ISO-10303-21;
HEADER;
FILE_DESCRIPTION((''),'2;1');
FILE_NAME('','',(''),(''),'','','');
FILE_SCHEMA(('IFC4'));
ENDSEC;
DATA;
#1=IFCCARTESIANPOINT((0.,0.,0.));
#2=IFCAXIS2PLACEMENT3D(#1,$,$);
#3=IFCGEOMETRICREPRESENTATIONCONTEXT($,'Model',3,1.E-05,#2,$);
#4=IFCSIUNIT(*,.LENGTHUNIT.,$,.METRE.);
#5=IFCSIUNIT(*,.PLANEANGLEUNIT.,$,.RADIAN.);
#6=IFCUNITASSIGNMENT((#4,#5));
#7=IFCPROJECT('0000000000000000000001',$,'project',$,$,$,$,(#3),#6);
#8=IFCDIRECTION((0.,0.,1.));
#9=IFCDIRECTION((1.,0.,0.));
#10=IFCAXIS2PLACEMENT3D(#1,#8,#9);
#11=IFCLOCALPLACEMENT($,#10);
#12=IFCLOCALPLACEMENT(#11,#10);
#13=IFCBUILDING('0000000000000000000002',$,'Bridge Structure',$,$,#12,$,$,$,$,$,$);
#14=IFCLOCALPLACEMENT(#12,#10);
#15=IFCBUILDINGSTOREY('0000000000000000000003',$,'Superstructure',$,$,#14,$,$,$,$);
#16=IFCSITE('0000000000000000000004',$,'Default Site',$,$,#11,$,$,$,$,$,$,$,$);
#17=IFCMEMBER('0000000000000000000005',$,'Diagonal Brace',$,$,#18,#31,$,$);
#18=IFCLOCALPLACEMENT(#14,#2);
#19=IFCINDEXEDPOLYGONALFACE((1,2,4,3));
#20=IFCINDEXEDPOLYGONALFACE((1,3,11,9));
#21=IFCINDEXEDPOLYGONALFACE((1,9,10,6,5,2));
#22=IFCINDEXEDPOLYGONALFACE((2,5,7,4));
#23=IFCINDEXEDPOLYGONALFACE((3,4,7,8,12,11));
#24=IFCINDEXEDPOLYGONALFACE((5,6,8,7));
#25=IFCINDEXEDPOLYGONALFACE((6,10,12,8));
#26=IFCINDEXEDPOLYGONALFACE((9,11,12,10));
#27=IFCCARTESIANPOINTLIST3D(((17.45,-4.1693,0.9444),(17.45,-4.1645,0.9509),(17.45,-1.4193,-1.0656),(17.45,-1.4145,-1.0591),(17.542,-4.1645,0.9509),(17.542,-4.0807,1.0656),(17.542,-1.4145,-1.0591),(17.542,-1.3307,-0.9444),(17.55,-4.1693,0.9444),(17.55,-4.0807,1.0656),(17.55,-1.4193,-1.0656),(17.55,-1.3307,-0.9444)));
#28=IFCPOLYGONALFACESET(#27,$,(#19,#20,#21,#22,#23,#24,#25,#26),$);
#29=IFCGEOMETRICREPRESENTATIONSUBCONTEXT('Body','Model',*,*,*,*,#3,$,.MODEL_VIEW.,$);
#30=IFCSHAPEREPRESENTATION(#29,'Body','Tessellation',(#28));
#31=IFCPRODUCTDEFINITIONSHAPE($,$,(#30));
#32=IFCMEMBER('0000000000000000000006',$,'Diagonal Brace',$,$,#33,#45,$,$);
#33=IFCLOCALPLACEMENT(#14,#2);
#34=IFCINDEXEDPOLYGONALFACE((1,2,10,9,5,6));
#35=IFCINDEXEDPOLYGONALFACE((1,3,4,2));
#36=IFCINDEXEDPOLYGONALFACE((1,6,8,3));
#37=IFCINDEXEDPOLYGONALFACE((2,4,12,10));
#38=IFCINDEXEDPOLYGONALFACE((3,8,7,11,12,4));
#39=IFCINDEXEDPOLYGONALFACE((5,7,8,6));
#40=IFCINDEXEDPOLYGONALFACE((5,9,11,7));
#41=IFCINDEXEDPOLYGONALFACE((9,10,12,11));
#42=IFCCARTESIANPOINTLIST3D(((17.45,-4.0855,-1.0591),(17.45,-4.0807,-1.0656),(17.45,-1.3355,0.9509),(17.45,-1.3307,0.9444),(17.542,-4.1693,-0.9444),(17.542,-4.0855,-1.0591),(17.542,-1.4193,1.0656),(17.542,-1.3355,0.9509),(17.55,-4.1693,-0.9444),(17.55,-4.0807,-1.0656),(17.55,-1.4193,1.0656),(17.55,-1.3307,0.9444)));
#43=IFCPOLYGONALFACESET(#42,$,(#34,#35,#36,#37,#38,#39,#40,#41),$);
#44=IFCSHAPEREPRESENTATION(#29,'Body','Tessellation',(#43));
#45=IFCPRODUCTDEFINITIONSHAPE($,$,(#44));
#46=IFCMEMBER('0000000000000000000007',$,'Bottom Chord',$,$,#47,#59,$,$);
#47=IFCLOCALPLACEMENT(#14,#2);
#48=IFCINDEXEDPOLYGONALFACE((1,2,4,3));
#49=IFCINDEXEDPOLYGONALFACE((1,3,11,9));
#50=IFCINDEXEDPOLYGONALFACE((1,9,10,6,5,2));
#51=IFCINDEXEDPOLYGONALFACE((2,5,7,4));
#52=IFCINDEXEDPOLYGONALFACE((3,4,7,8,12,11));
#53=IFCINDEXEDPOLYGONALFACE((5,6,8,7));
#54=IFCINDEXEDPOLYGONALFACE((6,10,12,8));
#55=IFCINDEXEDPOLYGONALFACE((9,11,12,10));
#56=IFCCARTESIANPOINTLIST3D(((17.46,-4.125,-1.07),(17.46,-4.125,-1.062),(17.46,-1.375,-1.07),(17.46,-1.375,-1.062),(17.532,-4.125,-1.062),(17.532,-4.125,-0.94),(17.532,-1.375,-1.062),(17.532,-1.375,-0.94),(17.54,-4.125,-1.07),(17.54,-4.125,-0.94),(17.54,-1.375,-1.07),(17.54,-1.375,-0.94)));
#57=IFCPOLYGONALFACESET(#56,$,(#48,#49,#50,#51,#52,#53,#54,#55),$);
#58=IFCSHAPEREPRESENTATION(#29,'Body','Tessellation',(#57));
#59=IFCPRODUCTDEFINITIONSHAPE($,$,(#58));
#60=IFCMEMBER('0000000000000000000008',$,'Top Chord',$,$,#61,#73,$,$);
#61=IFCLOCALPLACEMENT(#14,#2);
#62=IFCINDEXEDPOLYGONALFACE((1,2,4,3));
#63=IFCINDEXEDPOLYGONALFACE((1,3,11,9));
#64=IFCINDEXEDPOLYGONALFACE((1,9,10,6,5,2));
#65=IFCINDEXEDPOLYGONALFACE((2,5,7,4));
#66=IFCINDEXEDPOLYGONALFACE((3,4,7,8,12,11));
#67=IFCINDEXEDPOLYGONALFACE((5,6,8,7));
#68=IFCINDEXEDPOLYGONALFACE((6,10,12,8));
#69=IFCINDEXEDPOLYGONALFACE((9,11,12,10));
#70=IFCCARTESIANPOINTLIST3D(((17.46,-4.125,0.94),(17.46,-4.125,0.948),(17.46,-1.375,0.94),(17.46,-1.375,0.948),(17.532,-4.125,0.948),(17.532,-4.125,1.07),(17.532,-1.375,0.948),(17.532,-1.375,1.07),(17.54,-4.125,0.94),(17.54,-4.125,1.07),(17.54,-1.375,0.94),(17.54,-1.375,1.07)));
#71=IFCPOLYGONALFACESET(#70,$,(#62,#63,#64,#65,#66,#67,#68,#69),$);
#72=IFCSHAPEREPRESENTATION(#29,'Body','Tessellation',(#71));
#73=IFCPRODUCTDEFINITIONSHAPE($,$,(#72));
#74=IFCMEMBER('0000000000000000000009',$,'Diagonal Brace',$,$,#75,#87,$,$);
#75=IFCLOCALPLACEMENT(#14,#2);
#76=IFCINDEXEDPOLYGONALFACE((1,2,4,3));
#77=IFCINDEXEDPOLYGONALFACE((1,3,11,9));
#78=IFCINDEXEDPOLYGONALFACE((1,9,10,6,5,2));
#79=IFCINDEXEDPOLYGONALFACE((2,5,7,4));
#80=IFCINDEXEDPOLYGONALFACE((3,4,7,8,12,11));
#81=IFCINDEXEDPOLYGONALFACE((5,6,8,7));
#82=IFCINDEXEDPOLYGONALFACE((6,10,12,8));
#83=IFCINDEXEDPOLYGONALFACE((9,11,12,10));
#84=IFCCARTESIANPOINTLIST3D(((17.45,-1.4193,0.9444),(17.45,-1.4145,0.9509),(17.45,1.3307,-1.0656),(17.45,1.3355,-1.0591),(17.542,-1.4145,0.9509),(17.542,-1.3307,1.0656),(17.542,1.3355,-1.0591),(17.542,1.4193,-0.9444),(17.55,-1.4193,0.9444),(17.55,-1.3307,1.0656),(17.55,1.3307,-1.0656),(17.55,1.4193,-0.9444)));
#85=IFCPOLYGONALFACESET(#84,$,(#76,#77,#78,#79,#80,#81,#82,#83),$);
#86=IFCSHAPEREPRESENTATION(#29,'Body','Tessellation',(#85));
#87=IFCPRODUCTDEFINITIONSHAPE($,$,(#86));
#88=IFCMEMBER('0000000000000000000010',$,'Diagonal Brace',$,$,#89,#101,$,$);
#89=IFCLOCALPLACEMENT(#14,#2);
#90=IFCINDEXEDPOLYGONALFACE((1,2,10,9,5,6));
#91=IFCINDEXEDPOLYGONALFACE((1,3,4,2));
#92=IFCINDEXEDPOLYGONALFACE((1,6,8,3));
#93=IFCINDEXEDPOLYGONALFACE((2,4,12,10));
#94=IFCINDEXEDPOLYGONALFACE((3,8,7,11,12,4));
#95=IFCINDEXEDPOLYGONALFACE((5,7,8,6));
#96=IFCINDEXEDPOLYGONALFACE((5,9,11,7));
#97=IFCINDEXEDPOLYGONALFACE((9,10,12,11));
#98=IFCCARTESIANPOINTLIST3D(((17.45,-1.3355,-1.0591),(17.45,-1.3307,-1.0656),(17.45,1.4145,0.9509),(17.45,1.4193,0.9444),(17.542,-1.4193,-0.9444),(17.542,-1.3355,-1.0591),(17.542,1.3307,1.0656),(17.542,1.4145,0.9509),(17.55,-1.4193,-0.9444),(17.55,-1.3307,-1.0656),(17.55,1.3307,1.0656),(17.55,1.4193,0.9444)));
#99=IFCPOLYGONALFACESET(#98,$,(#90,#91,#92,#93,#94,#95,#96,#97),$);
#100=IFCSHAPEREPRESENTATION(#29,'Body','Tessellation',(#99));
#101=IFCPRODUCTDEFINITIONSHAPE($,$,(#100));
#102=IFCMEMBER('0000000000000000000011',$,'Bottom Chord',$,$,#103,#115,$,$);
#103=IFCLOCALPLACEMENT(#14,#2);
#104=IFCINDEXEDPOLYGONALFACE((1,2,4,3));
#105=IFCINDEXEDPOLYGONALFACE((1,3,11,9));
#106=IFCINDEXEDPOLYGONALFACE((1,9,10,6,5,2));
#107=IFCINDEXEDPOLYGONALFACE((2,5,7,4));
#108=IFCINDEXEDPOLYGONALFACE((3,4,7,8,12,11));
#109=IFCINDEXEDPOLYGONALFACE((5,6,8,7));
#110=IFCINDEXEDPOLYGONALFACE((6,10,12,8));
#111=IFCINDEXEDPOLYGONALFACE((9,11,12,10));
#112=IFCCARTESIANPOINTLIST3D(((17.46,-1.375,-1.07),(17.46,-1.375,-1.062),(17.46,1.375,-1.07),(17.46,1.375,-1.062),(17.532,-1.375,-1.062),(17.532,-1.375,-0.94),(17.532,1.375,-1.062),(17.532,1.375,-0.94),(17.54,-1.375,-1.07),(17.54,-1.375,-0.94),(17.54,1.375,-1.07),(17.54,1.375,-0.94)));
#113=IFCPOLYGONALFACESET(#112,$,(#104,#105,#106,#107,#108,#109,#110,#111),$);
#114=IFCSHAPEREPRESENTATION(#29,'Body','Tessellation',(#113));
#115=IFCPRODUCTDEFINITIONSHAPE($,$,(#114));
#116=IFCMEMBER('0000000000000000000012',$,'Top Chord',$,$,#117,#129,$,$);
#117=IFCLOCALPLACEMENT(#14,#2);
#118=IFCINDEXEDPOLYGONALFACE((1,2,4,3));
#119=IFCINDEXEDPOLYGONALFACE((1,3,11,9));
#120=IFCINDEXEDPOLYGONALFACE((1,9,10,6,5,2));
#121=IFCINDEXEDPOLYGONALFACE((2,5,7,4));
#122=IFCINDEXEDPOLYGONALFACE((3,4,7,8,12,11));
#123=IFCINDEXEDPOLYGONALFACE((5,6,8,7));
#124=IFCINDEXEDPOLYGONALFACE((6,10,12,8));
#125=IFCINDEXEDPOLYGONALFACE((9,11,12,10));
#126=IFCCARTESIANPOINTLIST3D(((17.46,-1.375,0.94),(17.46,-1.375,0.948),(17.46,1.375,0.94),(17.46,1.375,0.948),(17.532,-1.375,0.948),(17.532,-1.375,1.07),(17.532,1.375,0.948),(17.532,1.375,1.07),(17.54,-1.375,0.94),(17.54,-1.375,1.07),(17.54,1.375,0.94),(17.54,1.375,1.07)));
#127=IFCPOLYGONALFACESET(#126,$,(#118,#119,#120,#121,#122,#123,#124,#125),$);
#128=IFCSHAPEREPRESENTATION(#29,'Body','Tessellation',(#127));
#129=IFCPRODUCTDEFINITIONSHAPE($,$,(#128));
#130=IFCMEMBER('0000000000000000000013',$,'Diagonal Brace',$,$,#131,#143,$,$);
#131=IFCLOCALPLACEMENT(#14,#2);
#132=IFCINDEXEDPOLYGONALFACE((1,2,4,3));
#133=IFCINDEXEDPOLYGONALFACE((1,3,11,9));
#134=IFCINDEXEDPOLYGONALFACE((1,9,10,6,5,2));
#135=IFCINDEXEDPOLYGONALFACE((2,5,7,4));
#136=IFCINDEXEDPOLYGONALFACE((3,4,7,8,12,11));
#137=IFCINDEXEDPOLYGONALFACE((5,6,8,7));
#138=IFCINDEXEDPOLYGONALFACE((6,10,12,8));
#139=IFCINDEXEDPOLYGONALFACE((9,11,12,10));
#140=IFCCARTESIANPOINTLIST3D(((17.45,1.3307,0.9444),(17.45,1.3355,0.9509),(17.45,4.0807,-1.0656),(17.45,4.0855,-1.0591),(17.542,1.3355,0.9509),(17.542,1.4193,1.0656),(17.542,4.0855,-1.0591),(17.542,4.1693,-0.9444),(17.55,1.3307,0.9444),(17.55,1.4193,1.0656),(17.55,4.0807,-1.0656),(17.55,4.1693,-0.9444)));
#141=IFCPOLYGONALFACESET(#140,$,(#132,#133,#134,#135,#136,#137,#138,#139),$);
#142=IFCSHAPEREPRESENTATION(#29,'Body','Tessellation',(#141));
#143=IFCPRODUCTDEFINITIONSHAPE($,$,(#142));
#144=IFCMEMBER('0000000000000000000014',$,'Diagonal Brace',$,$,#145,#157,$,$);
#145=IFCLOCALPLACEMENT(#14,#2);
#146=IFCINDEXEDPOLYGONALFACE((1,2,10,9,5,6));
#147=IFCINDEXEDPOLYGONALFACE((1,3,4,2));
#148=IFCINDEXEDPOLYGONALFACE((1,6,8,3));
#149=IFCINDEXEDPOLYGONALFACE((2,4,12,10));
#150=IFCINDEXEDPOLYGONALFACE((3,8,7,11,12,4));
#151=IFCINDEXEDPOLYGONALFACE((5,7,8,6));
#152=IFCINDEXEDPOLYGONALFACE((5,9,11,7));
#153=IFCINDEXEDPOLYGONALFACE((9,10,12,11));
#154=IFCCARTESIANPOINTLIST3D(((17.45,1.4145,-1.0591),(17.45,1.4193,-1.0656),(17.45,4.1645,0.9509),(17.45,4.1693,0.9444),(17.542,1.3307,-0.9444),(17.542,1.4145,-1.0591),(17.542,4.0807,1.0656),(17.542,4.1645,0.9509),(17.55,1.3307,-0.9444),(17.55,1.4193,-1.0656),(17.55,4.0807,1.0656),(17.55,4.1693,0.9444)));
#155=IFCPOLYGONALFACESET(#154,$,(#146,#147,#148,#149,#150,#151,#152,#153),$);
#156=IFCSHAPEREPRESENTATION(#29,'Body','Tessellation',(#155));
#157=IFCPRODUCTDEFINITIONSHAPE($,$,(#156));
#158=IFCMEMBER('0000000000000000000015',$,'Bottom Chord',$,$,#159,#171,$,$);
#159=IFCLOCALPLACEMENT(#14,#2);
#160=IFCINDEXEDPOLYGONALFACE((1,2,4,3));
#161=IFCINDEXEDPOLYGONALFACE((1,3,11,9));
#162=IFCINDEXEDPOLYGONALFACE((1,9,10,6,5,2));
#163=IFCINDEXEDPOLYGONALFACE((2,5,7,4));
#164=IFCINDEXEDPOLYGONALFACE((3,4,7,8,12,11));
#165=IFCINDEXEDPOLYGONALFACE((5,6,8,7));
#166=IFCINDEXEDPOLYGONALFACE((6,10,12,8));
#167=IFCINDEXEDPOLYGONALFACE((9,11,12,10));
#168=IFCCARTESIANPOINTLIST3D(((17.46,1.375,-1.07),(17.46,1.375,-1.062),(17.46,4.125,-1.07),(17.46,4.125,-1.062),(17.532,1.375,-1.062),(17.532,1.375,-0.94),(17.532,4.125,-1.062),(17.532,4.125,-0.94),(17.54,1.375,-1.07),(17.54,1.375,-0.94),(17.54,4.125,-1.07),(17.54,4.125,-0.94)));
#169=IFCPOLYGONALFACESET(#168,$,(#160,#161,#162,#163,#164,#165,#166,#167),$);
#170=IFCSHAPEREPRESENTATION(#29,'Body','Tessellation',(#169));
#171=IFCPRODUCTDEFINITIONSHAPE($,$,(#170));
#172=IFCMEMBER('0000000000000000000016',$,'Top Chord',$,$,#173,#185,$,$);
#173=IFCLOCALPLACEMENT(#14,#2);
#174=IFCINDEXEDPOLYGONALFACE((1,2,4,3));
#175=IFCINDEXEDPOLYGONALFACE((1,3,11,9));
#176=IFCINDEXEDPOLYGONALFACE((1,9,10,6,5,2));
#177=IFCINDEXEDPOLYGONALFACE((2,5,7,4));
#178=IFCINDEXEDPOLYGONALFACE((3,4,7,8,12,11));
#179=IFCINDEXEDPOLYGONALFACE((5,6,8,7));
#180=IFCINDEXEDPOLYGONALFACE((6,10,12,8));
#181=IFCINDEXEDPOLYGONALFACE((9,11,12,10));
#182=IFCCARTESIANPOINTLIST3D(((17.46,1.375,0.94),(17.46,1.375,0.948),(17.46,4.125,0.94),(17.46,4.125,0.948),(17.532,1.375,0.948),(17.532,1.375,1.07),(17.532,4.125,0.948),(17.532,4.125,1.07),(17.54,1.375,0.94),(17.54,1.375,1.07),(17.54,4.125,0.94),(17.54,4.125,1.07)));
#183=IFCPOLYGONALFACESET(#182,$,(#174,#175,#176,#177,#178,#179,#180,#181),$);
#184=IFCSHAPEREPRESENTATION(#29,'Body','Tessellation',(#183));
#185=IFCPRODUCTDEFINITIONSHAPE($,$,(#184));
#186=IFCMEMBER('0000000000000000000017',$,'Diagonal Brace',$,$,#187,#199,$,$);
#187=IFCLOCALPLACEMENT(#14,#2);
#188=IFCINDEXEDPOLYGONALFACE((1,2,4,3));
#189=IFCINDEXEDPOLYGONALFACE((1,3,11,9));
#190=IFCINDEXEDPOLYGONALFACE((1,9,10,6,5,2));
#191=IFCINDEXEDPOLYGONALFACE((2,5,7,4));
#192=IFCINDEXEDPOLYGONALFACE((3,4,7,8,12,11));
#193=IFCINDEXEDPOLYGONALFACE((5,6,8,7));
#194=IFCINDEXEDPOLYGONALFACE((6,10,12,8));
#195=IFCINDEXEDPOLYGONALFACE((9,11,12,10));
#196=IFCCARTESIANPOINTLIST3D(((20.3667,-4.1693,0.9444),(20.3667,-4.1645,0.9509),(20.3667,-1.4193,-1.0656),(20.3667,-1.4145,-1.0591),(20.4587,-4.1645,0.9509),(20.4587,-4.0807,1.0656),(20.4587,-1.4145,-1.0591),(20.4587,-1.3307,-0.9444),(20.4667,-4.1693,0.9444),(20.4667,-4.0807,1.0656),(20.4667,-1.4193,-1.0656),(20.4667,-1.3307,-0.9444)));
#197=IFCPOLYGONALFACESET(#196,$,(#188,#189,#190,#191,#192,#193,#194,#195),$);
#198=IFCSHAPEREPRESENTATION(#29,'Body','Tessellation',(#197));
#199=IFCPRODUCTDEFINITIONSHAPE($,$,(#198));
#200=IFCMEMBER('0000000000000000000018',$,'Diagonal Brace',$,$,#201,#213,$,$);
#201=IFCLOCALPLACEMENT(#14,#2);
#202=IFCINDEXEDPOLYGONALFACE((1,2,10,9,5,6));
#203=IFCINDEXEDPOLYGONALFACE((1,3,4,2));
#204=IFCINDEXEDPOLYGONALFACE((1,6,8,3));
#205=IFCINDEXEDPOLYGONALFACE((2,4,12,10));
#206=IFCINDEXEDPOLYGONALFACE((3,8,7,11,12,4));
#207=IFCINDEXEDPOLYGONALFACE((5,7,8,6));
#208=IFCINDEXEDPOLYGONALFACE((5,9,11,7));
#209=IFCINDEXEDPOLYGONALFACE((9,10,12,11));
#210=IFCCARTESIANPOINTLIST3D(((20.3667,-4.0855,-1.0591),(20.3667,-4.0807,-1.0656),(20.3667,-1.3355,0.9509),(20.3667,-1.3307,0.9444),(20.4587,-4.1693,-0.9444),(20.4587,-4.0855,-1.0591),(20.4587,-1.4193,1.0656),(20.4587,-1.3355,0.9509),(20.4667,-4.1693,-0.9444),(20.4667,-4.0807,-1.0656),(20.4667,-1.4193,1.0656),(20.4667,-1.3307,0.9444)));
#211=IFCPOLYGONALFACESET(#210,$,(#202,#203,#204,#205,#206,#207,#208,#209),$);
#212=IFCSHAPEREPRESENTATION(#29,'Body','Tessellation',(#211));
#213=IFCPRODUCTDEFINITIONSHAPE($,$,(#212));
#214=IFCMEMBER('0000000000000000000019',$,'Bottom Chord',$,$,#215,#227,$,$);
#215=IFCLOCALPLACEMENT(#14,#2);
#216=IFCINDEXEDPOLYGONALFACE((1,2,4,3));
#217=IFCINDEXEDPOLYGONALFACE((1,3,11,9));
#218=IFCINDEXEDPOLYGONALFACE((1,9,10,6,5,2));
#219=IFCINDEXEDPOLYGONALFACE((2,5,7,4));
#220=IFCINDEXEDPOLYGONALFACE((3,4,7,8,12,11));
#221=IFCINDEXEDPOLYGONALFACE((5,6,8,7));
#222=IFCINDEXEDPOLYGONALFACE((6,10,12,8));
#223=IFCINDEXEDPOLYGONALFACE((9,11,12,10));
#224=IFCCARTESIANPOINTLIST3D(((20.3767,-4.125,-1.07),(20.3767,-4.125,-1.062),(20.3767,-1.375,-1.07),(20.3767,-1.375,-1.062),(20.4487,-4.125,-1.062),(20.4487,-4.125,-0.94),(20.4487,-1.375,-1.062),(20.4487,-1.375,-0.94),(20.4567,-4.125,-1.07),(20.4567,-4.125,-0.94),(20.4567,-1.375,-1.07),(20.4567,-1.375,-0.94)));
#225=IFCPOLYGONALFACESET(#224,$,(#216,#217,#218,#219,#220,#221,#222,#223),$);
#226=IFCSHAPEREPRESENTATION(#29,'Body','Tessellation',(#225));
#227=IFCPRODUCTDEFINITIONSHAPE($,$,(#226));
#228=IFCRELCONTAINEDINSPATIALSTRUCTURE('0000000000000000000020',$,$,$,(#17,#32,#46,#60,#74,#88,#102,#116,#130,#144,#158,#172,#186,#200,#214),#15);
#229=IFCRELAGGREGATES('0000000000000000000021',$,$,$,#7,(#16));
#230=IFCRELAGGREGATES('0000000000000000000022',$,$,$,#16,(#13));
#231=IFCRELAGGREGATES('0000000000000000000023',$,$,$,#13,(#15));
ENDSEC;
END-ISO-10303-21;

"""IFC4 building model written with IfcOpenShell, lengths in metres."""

from ifc_helpers import new_model, si_unit, frame, origin, origin_with_axes, origin_2d_with_axis, place, context, subcontext, project, spatial, l_section, extrude, element, save


model = new_model("IFC4")

# Units and contexts
model_context = context("Model", 3, precision=1e-05, world=origin())
body_context = subcontext(model_context, "Body", "Model", "MODEL_VIEW")
ifc_project = project(units=[si_unit("LENGTHUNIT", "METRE"), si_unit("PLANEANGLEUNIT", "RADIAN")], contexts=[model_context])

# Site, building, storey
site_placement = place(None, origin_with_axes())
site = spatial("IfcSite", under=ifc_project, at=site_placement, Name="Default Site")
building_placement = place(site_placement, origin_with_axes())
building = spatial("IfcBuilding", under=site, at=building_placement, Name="Bridge Structure")
storey_placement = place(building_placement, origin_with_axes())
storey = spatial("IfcBuildingStorey", under=building, at=storey_placement, Name="Superstructure")

# Members
for number, where, z_axis, x_axis, name in (
    (1, (17.5, -4.125, 1.005), (0.0, 0.807337, -0.59009), (-1.0, 0.0, 0.0), "Diagonal Brace"),
    (2, (17.5, -4.125, -1.005), (0.0, 0.807337, 0.59009), (-1.0, 0.0, 0.0), "Diagonal Brace"),
):
    element("IfcMember", number, at=place(storey_placement, frame(where, z_axis=z_axis, x_axis=x_axis)), inside=storey, Name=name, context=body_context, shape_type="SweptSolid", body=[
        extrude(l_section(Depth=0.15, Width=0.1, Thickness=0.008, at=origin_2d_with_axis()), origin_with_axes(), (0.0, 0.0, 1.0), 3.4063),
    ])
for number, where, z_axis, x_axis, name in (
    (3, (17.5, -4.125, -1.005), (0.0, 1.0, 0.0), (-1.0, 0.0, 0.0), "Bottom Chord"),
    (4, (17.5, -4.125, 1.005), (0.0, 1.0, 0.0), (-1.0, 0.0, 0.0), "Top Chord"),
):
    element("IfcMember", number, at=place(storey_placement, frame(where, z_axis=z_axis, x_axis=x_axis)), inside=storey, Name=name, context=body_context, shape_type="SweptSolid", body=[
        extrude(l_section(Depth=0.13, Width=0.08, Thickness=0.008, at=origin_2d_with_axis()), origin_with_axes(), (0.0, 0.0, 1.0), 2.75),
    ])
for number, where, z_axis, x_axis, name in (
    (5, (17.5, -1.375, 1.005), (0.0, 0.807337, -0.59009), (-1.0, 0.0, 0.0), "Diagonal Brace"),
    (6, (17.5, -1.375, -1.005), (0.0, 0.807337, 0.59009), (-1.0, 0.0, 0.0), "Diagonal Brace"),
):
    element("IfcMember", number, at=place(storey_placement, frame(where, z_axis=z_axis, x_axis=x_axis)), inside=storey, Name=name, context=body_context, shape_type="SweptSolid", body=[
        extrude(l_section(Depth=0.15, Width=0.1, Thickness=0.008, at=origin_2d_with_axis()), origin_with_axes(), (0.0, 0.0, 1.0), 3.4063),
    ])
for number, where, z_axis, x_axis, name in (
    (7, (17.5, -1.375, -1.005), (0.0, 1.0, 0.0), (-1.0, 0.0, 0.0), "Bottom Chord"),
    (8, (17.5, -1.375, 1.005), (0.0, 1.0, 0.0), (-1.0, 0.0, 0.0), "Top Chord"),
):
    element("IfcMember", number, at=place(storey_placement, frame(where, z_axis=z_axis, x_axis=x_axis)), inside=storey, Name=name, context=body_context, shape_type="SweptSolid", body=[
        extrude(l_section(Depth=0.13, Width=0.08, Thickness=0.008, at=origin_2d_with_axis()), origin_with_axes(), (0.0, 0.0, 1.0), 2.75),
    ])
for number, where, z_axis, x_axis, name in (
    (9, (17.5, 1.375, 1.005), (0.0, 0.807337, -0.59009), (-1.0, 0.0, 0.0), "Diagonal Brace"),
    (10, (17.5, 1.375, -1.005), (0.0, 0.807337, 0.59009), (-1.0, 0.0, 0.0), "Diagonal Brace"),
):
    element("IfcMember", number, at=place(storey_placement, frame(where, z_axis=z_axis, x_axis=x_axis)), inside=storey, Name=name, context=body_context, shape_type="SweptSolid", body=[
        extrude(l_section(Depth=0.15, Width=0.1, Thickness=0.008, at=origin_2d_with_axis()), origin_with_axes(), (0.0, 0.0, 1.0), 3.4063),
    ])
for number, where, z_axis, x_axis, name in (
    (11, (17.5, 1.375, -1.005), (0.0, 1.0, 0.0), (-1.0, 0.0, 0.0), "Bottom Chord"),
    (12, (17.5, 1.375, 1.005), (0.0, 1.0, 0.0), (-1.0, 0.0, 0.0), "Top Chord"),
):
    element("IfcMember", number, at=place(storey_placement, frame(where, z_axis=z_axis, x_axis=x_axis)), inside=storey, Name=name, context=body_context, shape_type="SweptSolid", body=[
        extrude(l_section(Depth=0.13, Width=0.08, Thickness=0.008, at=origin_2d_with_axis()), origin_with_axes(), (0.0, 0.0, 1.0), 2.75),
    ])
for number, where, z_axis, x_axis, name in (
    (13, (20.4167, -4.125, 1.005), (0.0, 0.807337, -0.59009), (-1.0, 0.0, 0.0), "Diagonal Brace"),
    (14, (20.4167, -4.125, -1.005), (0.0, 0.807337, 0.59009), (-1.0, 0.0, 0.0), "Diagonal Brace"),
):
    element("IfcMember", number, at=place(storey_placement, frame(where, z_axis=z_axis, x_axis=x_axis)), inside=storey, Name=name, context=body_context, shape_type="SweptSolid", body=[
        extrude(l_section(Depth=0.15, Width=0.1, Thickness=0.008, at=origin_2d_with_axis()), origin_with_axes(), (0.0, 0.0, 1.0), 3.4063),
    ])
for number, where, z_axis, x_axis, name in (
    (15, (20.4167, -4.125, -1.005), (0.0, 1.0, 0.0), (-1.0, 0.0, 0.0), "Bottom Chord"),
):
    element("IfcMember", number, at=place(storey_placement, frame(where, z_axis=z_axis, x_axis=x_axis)), inside=storey, Name=name, context=body_context, shape_type="SweptSolid", body=[
        extrude(l_section(Depth=0.13, Width=0.08, Thickness=0.008, at=origin_2d_with_axis()), origin_with_axes(), (0.0, 0.0, 1.0), 2.75),
    ])

save(model, "model.ifc")
